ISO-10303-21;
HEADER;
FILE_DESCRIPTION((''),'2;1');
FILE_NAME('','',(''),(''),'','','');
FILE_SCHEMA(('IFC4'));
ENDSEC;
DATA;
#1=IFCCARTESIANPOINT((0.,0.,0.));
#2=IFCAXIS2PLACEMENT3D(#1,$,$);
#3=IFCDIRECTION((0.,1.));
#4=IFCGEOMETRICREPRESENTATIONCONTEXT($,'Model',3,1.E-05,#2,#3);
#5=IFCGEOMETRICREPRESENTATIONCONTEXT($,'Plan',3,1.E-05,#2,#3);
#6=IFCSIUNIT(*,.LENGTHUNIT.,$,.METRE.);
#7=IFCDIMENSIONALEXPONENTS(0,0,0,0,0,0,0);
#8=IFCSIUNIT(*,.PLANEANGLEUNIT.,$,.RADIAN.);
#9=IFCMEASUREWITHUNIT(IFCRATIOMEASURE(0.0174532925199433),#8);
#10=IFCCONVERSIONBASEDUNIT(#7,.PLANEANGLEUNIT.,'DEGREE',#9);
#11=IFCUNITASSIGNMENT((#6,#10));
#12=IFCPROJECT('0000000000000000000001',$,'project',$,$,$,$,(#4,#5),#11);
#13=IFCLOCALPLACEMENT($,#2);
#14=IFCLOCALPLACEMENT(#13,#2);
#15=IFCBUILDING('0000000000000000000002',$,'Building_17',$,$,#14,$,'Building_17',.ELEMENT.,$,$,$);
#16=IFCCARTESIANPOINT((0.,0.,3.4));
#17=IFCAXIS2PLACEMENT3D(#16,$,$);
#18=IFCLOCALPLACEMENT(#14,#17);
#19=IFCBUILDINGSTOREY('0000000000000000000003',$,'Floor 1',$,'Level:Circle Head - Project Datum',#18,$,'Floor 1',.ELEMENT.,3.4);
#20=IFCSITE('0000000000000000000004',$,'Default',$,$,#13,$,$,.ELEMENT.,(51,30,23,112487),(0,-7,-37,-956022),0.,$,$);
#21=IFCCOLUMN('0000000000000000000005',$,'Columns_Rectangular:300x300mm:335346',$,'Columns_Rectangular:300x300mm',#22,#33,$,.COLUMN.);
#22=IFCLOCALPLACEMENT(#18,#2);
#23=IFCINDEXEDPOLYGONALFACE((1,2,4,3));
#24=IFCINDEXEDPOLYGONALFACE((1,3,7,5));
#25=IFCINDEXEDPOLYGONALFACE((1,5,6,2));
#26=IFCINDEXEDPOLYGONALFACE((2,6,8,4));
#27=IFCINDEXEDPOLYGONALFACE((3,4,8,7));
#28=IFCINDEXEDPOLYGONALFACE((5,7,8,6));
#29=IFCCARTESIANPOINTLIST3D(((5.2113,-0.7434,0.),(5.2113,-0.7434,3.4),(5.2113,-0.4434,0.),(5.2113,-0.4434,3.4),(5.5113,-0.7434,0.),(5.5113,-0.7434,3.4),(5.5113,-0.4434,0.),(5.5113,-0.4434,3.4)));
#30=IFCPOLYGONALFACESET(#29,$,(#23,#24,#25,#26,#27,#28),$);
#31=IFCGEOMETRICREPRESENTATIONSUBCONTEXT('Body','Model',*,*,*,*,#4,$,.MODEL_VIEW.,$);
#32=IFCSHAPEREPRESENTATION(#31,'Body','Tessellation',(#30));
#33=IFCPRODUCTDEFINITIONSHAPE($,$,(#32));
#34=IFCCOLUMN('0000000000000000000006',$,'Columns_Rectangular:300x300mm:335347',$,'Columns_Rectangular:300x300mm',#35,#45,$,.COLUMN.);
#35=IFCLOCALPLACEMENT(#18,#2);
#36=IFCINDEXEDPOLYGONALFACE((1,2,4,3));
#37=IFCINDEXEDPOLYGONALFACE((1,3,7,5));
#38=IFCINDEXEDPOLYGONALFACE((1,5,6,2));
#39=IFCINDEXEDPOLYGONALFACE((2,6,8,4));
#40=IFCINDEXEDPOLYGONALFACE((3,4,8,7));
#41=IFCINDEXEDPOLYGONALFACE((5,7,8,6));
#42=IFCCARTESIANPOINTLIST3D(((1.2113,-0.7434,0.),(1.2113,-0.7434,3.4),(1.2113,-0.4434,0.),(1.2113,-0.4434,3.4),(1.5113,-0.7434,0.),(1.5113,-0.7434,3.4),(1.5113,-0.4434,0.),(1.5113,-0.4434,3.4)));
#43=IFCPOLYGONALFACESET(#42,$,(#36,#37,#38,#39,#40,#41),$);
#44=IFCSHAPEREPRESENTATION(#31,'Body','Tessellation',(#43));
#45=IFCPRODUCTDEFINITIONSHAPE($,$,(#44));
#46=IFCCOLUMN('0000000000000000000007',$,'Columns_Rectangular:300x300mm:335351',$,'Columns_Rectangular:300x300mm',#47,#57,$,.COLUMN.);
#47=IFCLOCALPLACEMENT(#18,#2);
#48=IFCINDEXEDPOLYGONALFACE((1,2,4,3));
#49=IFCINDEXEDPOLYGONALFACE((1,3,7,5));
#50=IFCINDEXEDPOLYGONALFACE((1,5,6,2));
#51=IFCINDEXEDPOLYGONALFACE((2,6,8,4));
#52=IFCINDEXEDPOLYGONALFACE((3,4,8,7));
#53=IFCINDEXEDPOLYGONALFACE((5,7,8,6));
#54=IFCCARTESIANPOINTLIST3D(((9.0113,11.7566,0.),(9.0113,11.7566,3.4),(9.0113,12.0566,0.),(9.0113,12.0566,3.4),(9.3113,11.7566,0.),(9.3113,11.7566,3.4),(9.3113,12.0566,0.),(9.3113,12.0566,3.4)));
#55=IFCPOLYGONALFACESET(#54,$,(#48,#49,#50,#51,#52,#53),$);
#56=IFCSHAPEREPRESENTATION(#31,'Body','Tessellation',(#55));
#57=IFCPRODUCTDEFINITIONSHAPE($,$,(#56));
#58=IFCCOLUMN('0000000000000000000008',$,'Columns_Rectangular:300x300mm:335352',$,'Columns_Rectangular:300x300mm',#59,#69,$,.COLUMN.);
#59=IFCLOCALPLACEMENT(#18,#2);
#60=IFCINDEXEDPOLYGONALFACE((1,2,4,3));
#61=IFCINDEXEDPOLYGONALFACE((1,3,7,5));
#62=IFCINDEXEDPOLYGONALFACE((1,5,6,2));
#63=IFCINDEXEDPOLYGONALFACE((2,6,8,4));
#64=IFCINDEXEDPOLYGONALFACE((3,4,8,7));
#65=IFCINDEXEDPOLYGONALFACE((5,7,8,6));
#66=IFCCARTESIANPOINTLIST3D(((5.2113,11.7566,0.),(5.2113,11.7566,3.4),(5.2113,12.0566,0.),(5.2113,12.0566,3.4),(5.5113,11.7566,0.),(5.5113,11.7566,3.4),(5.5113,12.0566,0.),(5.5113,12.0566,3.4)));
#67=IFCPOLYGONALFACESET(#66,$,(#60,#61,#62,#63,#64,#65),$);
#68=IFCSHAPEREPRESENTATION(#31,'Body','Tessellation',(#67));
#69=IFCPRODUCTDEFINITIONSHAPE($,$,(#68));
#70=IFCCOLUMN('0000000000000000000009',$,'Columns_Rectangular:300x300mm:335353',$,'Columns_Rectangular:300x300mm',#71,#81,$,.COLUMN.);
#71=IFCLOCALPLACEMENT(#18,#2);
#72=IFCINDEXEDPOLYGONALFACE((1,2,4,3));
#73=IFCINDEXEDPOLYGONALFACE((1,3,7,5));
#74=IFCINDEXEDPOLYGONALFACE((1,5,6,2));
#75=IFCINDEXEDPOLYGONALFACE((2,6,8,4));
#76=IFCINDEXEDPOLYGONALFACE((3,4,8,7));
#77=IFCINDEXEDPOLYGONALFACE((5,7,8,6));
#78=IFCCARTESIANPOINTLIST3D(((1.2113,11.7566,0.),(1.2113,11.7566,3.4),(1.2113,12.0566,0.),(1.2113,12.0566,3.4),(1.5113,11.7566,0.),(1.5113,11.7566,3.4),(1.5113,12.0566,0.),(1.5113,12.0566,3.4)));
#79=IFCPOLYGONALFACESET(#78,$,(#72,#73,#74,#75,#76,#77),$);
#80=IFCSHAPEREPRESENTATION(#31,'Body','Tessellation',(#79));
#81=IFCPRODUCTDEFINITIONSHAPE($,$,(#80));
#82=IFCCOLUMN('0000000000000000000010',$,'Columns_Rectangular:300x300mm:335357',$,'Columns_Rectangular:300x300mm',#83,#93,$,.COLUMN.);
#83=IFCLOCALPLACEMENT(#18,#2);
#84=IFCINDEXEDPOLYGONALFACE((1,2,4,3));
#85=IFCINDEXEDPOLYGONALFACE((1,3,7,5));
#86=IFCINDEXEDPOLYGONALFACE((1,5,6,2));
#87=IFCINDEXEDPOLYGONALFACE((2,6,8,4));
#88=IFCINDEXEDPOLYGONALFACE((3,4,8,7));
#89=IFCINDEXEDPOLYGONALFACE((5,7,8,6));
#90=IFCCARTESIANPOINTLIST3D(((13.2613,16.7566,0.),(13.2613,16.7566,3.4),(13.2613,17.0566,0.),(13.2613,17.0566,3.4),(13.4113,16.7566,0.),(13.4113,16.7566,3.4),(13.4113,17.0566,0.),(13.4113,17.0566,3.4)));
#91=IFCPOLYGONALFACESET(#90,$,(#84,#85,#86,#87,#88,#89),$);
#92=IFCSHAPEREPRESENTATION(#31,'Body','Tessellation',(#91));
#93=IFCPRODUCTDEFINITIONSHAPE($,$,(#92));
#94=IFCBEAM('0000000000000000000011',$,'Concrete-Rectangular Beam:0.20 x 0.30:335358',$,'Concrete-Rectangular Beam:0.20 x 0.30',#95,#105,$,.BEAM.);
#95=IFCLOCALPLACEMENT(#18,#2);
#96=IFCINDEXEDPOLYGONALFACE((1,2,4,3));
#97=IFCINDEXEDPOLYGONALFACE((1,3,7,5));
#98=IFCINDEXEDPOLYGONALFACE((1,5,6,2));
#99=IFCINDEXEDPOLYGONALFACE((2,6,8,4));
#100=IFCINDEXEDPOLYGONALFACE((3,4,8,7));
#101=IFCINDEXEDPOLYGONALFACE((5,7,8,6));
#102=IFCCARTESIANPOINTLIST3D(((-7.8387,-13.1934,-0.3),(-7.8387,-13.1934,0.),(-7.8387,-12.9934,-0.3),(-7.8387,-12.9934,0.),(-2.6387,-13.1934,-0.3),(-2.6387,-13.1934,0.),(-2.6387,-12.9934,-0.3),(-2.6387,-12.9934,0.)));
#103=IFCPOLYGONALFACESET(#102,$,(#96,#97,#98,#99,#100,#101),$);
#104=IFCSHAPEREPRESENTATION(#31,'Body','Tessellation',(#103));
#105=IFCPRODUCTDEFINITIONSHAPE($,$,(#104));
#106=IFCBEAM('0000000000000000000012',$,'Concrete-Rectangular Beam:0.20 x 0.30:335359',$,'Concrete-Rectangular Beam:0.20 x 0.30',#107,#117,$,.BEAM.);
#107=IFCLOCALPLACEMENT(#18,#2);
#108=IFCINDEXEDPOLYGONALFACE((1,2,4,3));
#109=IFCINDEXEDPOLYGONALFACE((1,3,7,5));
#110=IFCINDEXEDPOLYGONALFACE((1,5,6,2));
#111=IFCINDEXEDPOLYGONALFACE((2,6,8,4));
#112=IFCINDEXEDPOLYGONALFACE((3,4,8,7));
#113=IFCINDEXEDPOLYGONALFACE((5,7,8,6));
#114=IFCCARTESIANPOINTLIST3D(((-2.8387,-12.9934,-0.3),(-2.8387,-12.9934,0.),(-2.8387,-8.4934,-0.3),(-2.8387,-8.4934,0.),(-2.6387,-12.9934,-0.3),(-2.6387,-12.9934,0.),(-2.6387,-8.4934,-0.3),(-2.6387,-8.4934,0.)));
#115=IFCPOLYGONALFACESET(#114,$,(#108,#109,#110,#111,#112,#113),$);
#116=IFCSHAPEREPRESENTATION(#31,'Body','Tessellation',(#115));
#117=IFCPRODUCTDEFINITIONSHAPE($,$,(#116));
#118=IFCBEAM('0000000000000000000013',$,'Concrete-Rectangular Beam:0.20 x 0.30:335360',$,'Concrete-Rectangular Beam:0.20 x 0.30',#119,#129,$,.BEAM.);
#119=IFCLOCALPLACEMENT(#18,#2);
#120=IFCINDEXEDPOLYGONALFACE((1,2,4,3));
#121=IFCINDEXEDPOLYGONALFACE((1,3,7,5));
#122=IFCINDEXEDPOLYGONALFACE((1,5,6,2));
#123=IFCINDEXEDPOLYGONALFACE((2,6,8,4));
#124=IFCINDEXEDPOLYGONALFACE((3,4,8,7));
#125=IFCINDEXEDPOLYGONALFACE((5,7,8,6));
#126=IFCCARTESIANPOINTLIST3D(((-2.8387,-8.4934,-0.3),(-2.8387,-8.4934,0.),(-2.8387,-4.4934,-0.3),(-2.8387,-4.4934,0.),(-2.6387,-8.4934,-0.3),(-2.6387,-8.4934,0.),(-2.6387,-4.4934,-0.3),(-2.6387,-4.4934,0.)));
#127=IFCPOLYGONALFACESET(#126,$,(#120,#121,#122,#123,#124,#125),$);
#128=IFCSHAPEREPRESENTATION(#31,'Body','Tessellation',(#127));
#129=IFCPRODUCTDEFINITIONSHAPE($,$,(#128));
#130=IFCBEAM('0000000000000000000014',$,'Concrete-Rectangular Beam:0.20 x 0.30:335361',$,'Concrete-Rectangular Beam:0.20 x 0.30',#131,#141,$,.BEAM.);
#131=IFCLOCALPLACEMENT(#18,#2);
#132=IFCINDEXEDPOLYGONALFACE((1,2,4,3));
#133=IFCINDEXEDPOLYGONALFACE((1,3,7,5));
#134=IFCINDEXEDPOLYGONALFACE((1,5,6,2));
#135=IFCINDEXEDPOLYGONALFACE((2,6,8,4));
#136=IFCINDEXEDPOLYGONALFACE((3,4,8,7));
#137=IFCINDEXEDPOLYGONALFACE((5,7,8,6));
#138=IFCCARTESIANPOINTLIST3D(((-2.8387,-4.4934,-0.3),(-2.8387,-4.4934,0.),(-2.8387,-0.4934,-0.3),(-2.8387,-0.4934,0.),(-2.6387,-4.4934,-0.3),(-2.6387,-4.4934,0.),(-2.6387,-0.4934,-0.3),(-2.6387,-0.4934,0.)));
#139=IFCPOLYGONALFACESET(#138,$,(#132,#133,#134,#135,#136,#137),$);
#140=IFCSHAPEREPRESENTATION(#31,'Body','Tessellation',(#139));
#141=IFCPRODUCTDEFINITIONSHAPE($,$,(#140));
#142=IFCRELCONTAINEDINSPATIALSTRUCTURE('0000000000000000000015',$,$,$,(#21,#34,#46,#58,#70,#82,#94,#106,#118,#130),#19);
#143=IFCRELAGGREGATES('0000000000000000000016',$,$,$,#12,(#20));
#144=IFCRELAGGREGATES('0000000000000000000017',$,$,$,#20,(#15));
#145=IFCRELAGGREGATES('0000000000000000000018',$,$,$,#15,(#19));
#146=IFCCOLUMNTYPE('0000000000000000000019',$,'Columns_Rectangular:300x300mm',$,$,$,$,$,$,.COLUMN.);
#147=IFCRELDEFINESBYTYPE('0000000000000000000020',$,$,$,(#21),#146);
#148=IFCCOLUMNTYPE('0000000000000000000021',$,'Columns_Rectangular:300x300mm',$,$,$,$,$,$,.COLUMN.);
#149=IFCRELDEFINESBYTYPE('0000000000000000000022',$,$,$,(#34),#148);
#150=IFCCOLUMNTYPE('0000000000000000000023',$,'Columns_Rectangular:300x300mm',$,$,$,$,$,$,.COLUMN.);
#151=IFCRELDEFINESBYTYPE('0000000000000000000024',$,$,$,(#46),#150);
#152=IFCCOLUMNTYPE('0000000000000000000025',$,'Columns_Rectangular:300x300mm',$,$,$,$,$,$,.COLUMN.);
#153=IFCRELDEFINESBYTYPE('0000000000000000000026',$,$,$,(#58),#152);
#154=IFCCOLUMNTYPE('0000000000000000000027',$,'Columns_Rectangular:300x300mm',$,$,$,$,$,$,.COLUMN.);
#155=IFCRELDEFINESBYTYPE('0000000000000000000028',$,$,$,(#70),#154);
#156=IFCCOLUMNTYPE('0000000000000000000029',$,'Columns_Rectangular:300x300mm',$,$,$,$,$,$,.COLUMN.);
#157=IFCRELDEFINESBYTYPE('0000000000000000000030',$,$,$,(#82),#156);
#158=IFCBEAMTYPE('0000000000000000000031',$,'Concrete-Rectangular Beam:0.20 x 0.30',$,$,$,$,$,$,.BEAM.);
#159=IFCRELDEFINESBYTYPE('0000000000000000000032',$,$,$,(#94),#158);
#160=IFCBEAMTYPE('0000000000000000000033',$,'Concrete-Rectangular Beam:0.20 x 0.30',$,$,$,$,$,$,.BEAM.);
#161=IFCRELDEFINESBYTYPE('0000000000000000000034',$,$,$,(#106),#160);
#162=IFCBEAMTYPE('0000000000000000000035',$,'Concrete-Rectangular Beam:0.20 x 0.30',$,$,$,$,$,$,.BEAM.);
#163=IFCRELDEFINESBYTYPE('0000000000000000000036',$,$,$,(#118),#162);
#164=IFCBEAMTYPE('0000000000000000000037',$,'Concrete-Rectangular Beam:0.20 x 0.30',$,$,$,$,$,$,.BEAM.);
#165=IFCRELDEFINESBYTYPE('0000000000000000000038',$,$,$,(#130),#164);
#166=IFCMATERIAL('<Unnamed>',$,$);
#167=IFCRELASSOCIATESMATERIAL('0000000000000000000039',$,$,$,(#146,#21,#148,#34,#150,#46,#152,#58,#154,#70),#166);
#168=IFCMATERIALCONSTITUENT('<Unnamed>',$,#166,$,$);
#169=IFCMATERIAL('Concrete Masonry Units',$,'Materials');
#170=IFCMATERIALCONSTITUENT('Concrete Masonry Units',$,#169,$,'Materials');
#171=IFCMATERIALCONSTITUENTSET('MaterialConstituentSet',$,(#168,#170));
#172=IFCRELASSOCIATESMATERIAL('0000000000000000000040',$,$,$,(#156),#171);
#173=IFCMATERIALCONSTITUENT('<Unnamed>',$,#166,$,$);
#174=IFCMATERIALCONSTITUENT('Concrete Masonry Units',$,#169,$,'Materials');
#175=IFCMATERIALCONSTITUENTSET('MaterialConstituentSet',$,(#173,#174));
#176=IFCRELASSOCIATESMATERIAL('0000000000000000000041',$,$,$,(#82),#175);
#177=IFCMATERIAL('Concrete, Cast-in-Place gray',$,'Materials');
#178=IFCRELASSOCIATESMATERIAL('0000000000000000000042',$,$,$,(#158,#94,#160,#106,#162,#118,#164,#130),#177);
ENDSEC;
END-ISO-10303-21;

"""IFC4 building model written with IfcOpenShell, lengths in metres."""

from ifc_helpers import new_model, entity, si_unit, converted_unit, direction, frame, origin, place, context, subcontext, project, spatial, indexed_curve, outline, extrude, source, transform, mapped, material, constituent, constituent_set, type_object, type_shapes, element, save


model = new_model("IFC4")

# Units and contexts
model_context = context("Model", 3, precision=1e-05, world=origin(), true_north=direction((0.0, 1.0)))
plan_context = context("Plan", 3, precision=1e-05, world=origin(), true_north=direction((0.0, 1.0)))
body_context = subcontext(model_context, "Body", "Model", "MODEL_VIEW")
ifc_project = project(units=[si_unit("LENGTHUNIT", "METRE"), converted_unit("PLANEANGLEUNIT", "DEGREE", entity("IfcRatioMeasure", 0.0174532925199433), si_unit("PLANEANGLEUNIT", "RADIAN"), dimensions=[0, 0, 0, 0, 0, 0, 0])], contexts=[model_context, plan_context])

# Site, building, storey
site_placement = place(None, origin())
site = spatial("IfcSite", under=ifc_project, at=site_placement, Name="Default", CompositionType="ELEMENT", RefLatitude=(51, 30, 23, 112487), RefLongitude=(0, -7, -37, -956022), RefElevation=0.0)
building_placement = place(site_placement, origin())
building = spatial("IfcBuilding", under=site, at=building_placement, Name="Building_17", LongName="Building_17", CompositionType="ELEMENT")
storey_placement = place(building_placement, frame((0.0, 0.0, 3.4)))
storey = spatial("IfcBuildingStorey", under=building, at=storey_placement, Name="Floor 1", ObjectType="Level:Circle Head - Project Datum", LongName="Floor 1", CompositionType="ELEMENT", Elevation=3.4)

# Columns
ifc_material_1 = material(Name="<Unnamed>")
ifc_material_2 = material(Name="Concrete Masonry Units", Category="Materials")
column_type_1 = type_object("IfcColumnType", Name="Columns_Rectangular:300x300mm", PredefinedType="COLUMN", material=ifc_material_1)
shared_shape_1 = source(origin(), body_context, "Body", "SweptSolid", [
    extrude(outline(indexed_curve([(-0.15, -0.15), (0.15, -0.15), (0.15, 0.15), (-0.15, 0.15), (-0.15, -0.15)], self_intersect=False)), frame((5.3613, -0.5934, 3.4), z_axis=(0.0, 0.0, 1.0), x_axis=(0.0, -1.0, 0.0)), (0.0, 0.0, 1.0), 3.4),
])
type_shapes(column_type_1, [shared_shape_1])
column_1_placement = place(storey_placement, frame((0.0, 0.0, -3.4)))
element("IfcColumn", 1, at=column_1_placement, inside=storey, type_object=column_type_1, material=ifc_material_1, Name="Columns_Rectangular:300x300mm:335346", ObjectType="Columns_Rectangular:300x300mm", PredefinedType="COLUMN", context=body_context, shape_type="MappedRepresentation", body=[
    mapped(shared_shape_1, transform((0.0, 0.0, 0.0), scale=1.0)),
])
column_type_2 = type_object("IfcColumnType", Name="Columns_Rectangular:300x300mm", PredefinedType="COLUMN", material=ifc_material_1)
shared_shape_2 = source(origin(), body_context, "Body", "SweptSolid", [
    extrude(outline(indexed_curve([(-0.15, -0.15), (0.15, -0.15), (0.15, 0.15), (-0.15, 0.15), (-0.15, -0.15)], self_intersect=False)), frame((1.3613, -0.5934, 3.4), z_axis=(0.0, 0.0, 1.0), x_axis=(0.0, -1.0, 0.0)), (0.0, 0.0, 1.0), 3.4),
])
type_shapes(column_type_2, [shared_shape_2])
column_2_placement = place(storey_placement, frame((0.0, 0.0, -3.4)))
element("IfcColumn", 2, at=column_2_placement, inside=storey, type_object=column_type_2, material=ifc_material_1, Name="Columns_Rectangular:300x300mm:335347", ObjectType="Columns_Rectangular:300x300mm", PredefinedType="COLUMN", context=body_context, shape_type="MappedRepresentation", body=[
    mapped(shared_shape_2, transform((0.0, 0.0, 0.0), scale=1.0)),
])
column_type_3 = type_object("IfcColumnType", Name="Columns_Rectangular:300x300mm", PredefinedType="COLUMN", material=ifc_material_1)
shared_shape_3 = source(origin(), body_context, "Body", "SweptSolid", [
    extrude(outline(indexed_curve([(-0.15, -0.15), (0.15, -0.15), (0.15, 0.15), (-0.15, 0.15), (-0.15, -0.15)], self_intersect=False)), frame((9.1613, 11.9066, 3.4), z_axis=(0.0, 0.0, 1.0), x_axis=(0.0, -1.0, 0.0)), (0.0, 0.0, 1.0), 3.4),
])
type_shapes(column_type_3, [shared_shape_3])
column_3_placement = place(storey_placement, frame((0.0, 0.0, -3.4)))
element("IfcColumn", 3, at=column_3_placement, inside=storey, type_object=column_type_3, material=ifc_material_1, Name="Columns_Rectangular:300x300mm:335351", ObjectType="Columns_Rectangular:300x300mm", PredefinedType="COLUMN", context=body_context, shape_type="MappedRepresentation", body=[
    mapped(shared_shape_3, transform((0.0, 0.0, 0.0), scale=1.0)),
])
column_type_4 = type_object("IfcColumnType", Name="Columns_Rectangular:300x300mm", PredefinedType="COLUMN", material=ifc_material_1)
shared_shape_4 = source(origin(), body_context, "Body", "SweptSolid", [
    extrude(outline(indexed_curve([(-0.15, -0.15), (0.15, -0.15), (0.15, 0.15), (-0.15, 0.15), (-0.15, -0.15)], self_intersect=False)), frame((5.3613, 11.9066, 3.4), z_axis=(0.0, 0.0, 1.0), x_axis=(0.0, -1.0, 0.0)), (0.0, 0.0, 1.0), 3.4),
])
type_shapes(column_type_4, [shared_shape_4])
column_4_placement = place(storey_placement, frame((0.0, 0.0, -3.4)))
element("IfcColumn", 4, at=column_4_placement, inside=storey, type_object=column_type_4, material=ifc_material_1, Name="Columns_Rectangular:300x300mm:335352", ObjectType="Columns_Rectangular:300x300mm", PredefinedType="COLUMN", context=body_context, shape_type="MappedRepresentation", body=[
    mapped(shared_shape_4, transform((0.0, 0.0, 0.0), scale=1.0)),
])
column_type_5 = type_object("IfcColumnType", Name="Columns_Rectangular:300x300mm", PredefinedType="COLUMN", material=ifc_material_1)
shared_shape_5 = source(origin(), body_context, "Body", "SweptSolid", [
    extrude(outline(indexed_curve([(-0.15, -0.15), (0.15, -0.15), (0.15, 0.15), (-0.15, 0.15), (-0.15, -0.15)], self_intersect=False)), frame((1.3613, 11.9066, 3.4), z_axis=(0.0, 0.0, 1.0), x_axis=(0.0, -1.0, 0.0)), (0.0, 0.0, 1.0), 3.4),
])
type_shapes(column_type_5, [shared_shape_5])
column_5_placement = place(storey_placement, frame((0.0, 0.0, -3.4)))
element("IfcColumn", 5, at=column_5_placement, inside=storey, type_object=column_type_5, material=ifc_material_1, Name="Columns_Rectangular:300x300mm:335353", ObjectType="Columns_Rectangular:300x300mm", PredefinedType="COLUMN", context=body_context, shape_type="MappedRepresentation", body=[
    mapped(shared_shape_5, transform((0.0, 0.0, 0.0), scale=1.0)),
])
ifc_constituent_1 = constituent(ifc_material_1, Name="<Unnamed>")
ifc_constituent_2 = constituent(ifc_material_2, Name="Concrete Masonry Units", Category="Materials")
ifc_constituent_set_1 = constituent_set(constituents=[ifc_constituent_1, ifc_constituent_2], Name="MaterialConstituentSet")
ifc_constituent_3 = constituent(ifc_material_1, Name="<Unnamed>")
ifc_constituent_4 = constituent(ifc_material_2, Name="Concrete Masonry Units", Category="Materials")
ifc_constituent_set_2 = constituent_set(constituents=[ifc_constituent_3, ifc_constituent_4], Name="MaterialConstituentSet")
column_type_6 = type_object("IfcColumnType", Name="Columns_Rectangular:300x300mm", PredefinedType="COLUMN", material=ifc_constituent_set_2)
shared_shape_6 = source(origin(), body_context, "Body", "SweptSolid", [
    extrude(outline(indexed_curve([(-0.15, -0.075), (0.15, -0.075), (0.15, 0.075), (-0.15, 0.075), (-0.15, -0.075)], self_intersect=False)), frame((13.3363, 16.9066, 3.4), z_axis=(0.0, 0.0, 1.0), x_axis=(0.0, -1.0, 0.0)), (0.0, 0.0, 1.0), 3.4),
])
type_shapes(column_type_6, [shared_shape_6])
column_6_placement = place(storey_placement, frame((0.0, 0.0, -3.4)))
element("IfcColumn", 6, at=column_6_placement, inside=storey, type_object=column_type_6, material=ifc_constituent_set_1, Name="Columns_Rectangular:300x300mm:335357", ObjectType="Columns_Rectangular:300x300mm", PredefinedType="COLUMN", context=body_context, shape_type="MappedRepresentation", body=[
    mapped(shared_shape_6, transform((0.0, 0.0, 0.0), scale=1.0)),
])

# Beams
ifc_material_3 = material(Name="Concrete, Cast-in-Place gray", Category="Materials")
beam_type_1 = type_object("IfcBeamType", Name="Concrete-Rectangular Beam:0.20 x 0.30", PredefinedType="BEAM", material=ifc_material_3)
shared_shape_7 = source(origin(), body_context, "Body", "SweptSolid", [
    extrude(outline(indexed_curve([(-0.15, -0.1), (0.15, -0.1), (0.15, 0.1), (-0.15, 0.1), (-0.15, -0.1)], self_intersect=False)), frame((-7.8387, -13.0934, 3.25), z_axis=(1.0, 0.0, 0.0), x_axis=(0.0, 0.0, -1.0)), (0.0, 0.0, 1.0), 5.2),
])
type_shapes(beam_type_1, [shared_shape_7])
beam_1_placement = place(storey_placement, frame((0.0, 0.0, -3.4)))
element("IfcBeam", 7, at=beam_1_placement, inside=storey, type_object=beam_type_1, material=ifc_material_3, Name="Concrete-Rectangular Beam:0.20 x 0.30:335358", ObjectType="Concrete-Rectangular Beam:0.20 x 0.30", PredefinedType="BEAM", context=body_context, shape_type="MappedRepresentation", body=[
    mapped(shared_shape_7, transform((0.0, 0.0, 0.0), scale=1.0)),
])
beam_type_2 = type_object("IfcBeamType", Name="Concrete-Rectangular Beam:0.20 x 0.30", PredefinedType="BEAM", material=ifc_material_3)
shared_shape_8 = source(origin(), body_context, "Body", "SweptSolid", [
    extrude(outline(indexed_curve([(-0.1, -0.15), (0.1, -0.15), (0.1, 0.15), (-0.1, 0.15), (-0.1, -0.15)], self_intersect=False)), frame((-2.7387, -12.9934, 3.25), z_axis=(0.0, 1.0, 0.0), x_axis=(-1.0, 0.0, 0.0)), (0.0, 0.0, 1.0), 4.5),
])
type_shapes(beam_type_2, [shared_shape_8])
beam_2_placement = place(storey_placement, frame((0.0, 0.0, -3.4)))
element("IfcBeam", 8, at=beam_2_placement, inside=storey, type_object=beam_type_2, material=ifc_material_3, Name="Concrete-Rectangular Beam:0.20 x 0.30:335359", ObjectType="Concrete-Rectangular Beam:0.20 x 0.30", PredefinedType="BEAM", context=body_context, shape_type="MappedRepresentation", body=[
    mapped(shared_shape_8, transform((0.0, 0.0, 0.0), scale=1.0)),
])
beam_type_3 = type_object("IfcBeamType", Name="Concrete-Rectangular Beam:0.20 x 0.30", PredefinedType="BEAM", material=ifc_material_3)
shared_shape_9 = source(origin(), body_context, "Body", "SweptSolid", [
    extrude(outline(indexed_curve([(-0.1, -0.15), (0.1, -0.15), (0.1, 0.15), (-0.1, 0.15), (-0.1, -0.15)], self_intersect=False)), frame((-2.7387, -8.4934, 3.25), z_axis=(0.0, 1.0, 0.0), x_axis=(-1.0, 0.0, 0.0)), (0.0, 0.0, 1.0), 4.0),
])
type_shapes(beam_type_3, [shared_shape_9])
beam_3_placement = place(storey_placement, frame((0.0, 0.0, -3.4)))
element("IfcBeam", 9, at=beam_3_placement, inside=storey, type_object=beam_type_3, material=ifc_material_3, Name="Concrete-Rectangular Beam:0.20 x 0.30:335360", ObjectType="Concrete-Rectangular Beam:0.20 x 0.30", PredefinedType="BEAM", context=body_context, shape_type="MappedRepresentation", body=[
    mapped(shared_shape_9, transform((0.0, 0.0, 0.0), scale=1.0)),
])
beam_type_4 = type_object("IfcBeamType", Name="Concrete-Rectangular Beam:0.20 x 0.30", PredefinedType="BEAM", material=ifc_material_3)
shared_shape_10 = source(origin(), body_context, "Body", "SweptSolid", [
    extrude(outline(indexed_curve([(-0.1, -0.15), (0.1, -0.15), (0.1, 0.15), (-0.1, 0.15), (-0.1, -0.15)], self_intersect=False)), frame((-2.7387, -4.4934, 3.25), z_axis=(0.0, 1.0, 0.0), x_axis=(-1.0, 0.0, 0.0)), (0.0, 0.0, 1.0), 4.0),
])
type_shapes(beam_type_4, [shared_shape_10])
beam_4_placement = place(storey_placement, frame((0.0, 0.0, -3.4)))
element("IfcBeam", 10, at=beam_4_placement, inside=storey, type_object=beam_type_4, material=ifc_material_3, Name="Concrete-Rectangular Beam:0.20 x 0.30:335361", ObjectType="Concrete-Rectangular Beam:0.20 x 0.30", PredefinedType="BEAM", context=body_context, shape_type="MappedRepresentation", body=[
    mapped(shared_shape_10, transform((0.0, 0.0, 0.0), scale=1.0)),
])

save(model, "model.ifc")
